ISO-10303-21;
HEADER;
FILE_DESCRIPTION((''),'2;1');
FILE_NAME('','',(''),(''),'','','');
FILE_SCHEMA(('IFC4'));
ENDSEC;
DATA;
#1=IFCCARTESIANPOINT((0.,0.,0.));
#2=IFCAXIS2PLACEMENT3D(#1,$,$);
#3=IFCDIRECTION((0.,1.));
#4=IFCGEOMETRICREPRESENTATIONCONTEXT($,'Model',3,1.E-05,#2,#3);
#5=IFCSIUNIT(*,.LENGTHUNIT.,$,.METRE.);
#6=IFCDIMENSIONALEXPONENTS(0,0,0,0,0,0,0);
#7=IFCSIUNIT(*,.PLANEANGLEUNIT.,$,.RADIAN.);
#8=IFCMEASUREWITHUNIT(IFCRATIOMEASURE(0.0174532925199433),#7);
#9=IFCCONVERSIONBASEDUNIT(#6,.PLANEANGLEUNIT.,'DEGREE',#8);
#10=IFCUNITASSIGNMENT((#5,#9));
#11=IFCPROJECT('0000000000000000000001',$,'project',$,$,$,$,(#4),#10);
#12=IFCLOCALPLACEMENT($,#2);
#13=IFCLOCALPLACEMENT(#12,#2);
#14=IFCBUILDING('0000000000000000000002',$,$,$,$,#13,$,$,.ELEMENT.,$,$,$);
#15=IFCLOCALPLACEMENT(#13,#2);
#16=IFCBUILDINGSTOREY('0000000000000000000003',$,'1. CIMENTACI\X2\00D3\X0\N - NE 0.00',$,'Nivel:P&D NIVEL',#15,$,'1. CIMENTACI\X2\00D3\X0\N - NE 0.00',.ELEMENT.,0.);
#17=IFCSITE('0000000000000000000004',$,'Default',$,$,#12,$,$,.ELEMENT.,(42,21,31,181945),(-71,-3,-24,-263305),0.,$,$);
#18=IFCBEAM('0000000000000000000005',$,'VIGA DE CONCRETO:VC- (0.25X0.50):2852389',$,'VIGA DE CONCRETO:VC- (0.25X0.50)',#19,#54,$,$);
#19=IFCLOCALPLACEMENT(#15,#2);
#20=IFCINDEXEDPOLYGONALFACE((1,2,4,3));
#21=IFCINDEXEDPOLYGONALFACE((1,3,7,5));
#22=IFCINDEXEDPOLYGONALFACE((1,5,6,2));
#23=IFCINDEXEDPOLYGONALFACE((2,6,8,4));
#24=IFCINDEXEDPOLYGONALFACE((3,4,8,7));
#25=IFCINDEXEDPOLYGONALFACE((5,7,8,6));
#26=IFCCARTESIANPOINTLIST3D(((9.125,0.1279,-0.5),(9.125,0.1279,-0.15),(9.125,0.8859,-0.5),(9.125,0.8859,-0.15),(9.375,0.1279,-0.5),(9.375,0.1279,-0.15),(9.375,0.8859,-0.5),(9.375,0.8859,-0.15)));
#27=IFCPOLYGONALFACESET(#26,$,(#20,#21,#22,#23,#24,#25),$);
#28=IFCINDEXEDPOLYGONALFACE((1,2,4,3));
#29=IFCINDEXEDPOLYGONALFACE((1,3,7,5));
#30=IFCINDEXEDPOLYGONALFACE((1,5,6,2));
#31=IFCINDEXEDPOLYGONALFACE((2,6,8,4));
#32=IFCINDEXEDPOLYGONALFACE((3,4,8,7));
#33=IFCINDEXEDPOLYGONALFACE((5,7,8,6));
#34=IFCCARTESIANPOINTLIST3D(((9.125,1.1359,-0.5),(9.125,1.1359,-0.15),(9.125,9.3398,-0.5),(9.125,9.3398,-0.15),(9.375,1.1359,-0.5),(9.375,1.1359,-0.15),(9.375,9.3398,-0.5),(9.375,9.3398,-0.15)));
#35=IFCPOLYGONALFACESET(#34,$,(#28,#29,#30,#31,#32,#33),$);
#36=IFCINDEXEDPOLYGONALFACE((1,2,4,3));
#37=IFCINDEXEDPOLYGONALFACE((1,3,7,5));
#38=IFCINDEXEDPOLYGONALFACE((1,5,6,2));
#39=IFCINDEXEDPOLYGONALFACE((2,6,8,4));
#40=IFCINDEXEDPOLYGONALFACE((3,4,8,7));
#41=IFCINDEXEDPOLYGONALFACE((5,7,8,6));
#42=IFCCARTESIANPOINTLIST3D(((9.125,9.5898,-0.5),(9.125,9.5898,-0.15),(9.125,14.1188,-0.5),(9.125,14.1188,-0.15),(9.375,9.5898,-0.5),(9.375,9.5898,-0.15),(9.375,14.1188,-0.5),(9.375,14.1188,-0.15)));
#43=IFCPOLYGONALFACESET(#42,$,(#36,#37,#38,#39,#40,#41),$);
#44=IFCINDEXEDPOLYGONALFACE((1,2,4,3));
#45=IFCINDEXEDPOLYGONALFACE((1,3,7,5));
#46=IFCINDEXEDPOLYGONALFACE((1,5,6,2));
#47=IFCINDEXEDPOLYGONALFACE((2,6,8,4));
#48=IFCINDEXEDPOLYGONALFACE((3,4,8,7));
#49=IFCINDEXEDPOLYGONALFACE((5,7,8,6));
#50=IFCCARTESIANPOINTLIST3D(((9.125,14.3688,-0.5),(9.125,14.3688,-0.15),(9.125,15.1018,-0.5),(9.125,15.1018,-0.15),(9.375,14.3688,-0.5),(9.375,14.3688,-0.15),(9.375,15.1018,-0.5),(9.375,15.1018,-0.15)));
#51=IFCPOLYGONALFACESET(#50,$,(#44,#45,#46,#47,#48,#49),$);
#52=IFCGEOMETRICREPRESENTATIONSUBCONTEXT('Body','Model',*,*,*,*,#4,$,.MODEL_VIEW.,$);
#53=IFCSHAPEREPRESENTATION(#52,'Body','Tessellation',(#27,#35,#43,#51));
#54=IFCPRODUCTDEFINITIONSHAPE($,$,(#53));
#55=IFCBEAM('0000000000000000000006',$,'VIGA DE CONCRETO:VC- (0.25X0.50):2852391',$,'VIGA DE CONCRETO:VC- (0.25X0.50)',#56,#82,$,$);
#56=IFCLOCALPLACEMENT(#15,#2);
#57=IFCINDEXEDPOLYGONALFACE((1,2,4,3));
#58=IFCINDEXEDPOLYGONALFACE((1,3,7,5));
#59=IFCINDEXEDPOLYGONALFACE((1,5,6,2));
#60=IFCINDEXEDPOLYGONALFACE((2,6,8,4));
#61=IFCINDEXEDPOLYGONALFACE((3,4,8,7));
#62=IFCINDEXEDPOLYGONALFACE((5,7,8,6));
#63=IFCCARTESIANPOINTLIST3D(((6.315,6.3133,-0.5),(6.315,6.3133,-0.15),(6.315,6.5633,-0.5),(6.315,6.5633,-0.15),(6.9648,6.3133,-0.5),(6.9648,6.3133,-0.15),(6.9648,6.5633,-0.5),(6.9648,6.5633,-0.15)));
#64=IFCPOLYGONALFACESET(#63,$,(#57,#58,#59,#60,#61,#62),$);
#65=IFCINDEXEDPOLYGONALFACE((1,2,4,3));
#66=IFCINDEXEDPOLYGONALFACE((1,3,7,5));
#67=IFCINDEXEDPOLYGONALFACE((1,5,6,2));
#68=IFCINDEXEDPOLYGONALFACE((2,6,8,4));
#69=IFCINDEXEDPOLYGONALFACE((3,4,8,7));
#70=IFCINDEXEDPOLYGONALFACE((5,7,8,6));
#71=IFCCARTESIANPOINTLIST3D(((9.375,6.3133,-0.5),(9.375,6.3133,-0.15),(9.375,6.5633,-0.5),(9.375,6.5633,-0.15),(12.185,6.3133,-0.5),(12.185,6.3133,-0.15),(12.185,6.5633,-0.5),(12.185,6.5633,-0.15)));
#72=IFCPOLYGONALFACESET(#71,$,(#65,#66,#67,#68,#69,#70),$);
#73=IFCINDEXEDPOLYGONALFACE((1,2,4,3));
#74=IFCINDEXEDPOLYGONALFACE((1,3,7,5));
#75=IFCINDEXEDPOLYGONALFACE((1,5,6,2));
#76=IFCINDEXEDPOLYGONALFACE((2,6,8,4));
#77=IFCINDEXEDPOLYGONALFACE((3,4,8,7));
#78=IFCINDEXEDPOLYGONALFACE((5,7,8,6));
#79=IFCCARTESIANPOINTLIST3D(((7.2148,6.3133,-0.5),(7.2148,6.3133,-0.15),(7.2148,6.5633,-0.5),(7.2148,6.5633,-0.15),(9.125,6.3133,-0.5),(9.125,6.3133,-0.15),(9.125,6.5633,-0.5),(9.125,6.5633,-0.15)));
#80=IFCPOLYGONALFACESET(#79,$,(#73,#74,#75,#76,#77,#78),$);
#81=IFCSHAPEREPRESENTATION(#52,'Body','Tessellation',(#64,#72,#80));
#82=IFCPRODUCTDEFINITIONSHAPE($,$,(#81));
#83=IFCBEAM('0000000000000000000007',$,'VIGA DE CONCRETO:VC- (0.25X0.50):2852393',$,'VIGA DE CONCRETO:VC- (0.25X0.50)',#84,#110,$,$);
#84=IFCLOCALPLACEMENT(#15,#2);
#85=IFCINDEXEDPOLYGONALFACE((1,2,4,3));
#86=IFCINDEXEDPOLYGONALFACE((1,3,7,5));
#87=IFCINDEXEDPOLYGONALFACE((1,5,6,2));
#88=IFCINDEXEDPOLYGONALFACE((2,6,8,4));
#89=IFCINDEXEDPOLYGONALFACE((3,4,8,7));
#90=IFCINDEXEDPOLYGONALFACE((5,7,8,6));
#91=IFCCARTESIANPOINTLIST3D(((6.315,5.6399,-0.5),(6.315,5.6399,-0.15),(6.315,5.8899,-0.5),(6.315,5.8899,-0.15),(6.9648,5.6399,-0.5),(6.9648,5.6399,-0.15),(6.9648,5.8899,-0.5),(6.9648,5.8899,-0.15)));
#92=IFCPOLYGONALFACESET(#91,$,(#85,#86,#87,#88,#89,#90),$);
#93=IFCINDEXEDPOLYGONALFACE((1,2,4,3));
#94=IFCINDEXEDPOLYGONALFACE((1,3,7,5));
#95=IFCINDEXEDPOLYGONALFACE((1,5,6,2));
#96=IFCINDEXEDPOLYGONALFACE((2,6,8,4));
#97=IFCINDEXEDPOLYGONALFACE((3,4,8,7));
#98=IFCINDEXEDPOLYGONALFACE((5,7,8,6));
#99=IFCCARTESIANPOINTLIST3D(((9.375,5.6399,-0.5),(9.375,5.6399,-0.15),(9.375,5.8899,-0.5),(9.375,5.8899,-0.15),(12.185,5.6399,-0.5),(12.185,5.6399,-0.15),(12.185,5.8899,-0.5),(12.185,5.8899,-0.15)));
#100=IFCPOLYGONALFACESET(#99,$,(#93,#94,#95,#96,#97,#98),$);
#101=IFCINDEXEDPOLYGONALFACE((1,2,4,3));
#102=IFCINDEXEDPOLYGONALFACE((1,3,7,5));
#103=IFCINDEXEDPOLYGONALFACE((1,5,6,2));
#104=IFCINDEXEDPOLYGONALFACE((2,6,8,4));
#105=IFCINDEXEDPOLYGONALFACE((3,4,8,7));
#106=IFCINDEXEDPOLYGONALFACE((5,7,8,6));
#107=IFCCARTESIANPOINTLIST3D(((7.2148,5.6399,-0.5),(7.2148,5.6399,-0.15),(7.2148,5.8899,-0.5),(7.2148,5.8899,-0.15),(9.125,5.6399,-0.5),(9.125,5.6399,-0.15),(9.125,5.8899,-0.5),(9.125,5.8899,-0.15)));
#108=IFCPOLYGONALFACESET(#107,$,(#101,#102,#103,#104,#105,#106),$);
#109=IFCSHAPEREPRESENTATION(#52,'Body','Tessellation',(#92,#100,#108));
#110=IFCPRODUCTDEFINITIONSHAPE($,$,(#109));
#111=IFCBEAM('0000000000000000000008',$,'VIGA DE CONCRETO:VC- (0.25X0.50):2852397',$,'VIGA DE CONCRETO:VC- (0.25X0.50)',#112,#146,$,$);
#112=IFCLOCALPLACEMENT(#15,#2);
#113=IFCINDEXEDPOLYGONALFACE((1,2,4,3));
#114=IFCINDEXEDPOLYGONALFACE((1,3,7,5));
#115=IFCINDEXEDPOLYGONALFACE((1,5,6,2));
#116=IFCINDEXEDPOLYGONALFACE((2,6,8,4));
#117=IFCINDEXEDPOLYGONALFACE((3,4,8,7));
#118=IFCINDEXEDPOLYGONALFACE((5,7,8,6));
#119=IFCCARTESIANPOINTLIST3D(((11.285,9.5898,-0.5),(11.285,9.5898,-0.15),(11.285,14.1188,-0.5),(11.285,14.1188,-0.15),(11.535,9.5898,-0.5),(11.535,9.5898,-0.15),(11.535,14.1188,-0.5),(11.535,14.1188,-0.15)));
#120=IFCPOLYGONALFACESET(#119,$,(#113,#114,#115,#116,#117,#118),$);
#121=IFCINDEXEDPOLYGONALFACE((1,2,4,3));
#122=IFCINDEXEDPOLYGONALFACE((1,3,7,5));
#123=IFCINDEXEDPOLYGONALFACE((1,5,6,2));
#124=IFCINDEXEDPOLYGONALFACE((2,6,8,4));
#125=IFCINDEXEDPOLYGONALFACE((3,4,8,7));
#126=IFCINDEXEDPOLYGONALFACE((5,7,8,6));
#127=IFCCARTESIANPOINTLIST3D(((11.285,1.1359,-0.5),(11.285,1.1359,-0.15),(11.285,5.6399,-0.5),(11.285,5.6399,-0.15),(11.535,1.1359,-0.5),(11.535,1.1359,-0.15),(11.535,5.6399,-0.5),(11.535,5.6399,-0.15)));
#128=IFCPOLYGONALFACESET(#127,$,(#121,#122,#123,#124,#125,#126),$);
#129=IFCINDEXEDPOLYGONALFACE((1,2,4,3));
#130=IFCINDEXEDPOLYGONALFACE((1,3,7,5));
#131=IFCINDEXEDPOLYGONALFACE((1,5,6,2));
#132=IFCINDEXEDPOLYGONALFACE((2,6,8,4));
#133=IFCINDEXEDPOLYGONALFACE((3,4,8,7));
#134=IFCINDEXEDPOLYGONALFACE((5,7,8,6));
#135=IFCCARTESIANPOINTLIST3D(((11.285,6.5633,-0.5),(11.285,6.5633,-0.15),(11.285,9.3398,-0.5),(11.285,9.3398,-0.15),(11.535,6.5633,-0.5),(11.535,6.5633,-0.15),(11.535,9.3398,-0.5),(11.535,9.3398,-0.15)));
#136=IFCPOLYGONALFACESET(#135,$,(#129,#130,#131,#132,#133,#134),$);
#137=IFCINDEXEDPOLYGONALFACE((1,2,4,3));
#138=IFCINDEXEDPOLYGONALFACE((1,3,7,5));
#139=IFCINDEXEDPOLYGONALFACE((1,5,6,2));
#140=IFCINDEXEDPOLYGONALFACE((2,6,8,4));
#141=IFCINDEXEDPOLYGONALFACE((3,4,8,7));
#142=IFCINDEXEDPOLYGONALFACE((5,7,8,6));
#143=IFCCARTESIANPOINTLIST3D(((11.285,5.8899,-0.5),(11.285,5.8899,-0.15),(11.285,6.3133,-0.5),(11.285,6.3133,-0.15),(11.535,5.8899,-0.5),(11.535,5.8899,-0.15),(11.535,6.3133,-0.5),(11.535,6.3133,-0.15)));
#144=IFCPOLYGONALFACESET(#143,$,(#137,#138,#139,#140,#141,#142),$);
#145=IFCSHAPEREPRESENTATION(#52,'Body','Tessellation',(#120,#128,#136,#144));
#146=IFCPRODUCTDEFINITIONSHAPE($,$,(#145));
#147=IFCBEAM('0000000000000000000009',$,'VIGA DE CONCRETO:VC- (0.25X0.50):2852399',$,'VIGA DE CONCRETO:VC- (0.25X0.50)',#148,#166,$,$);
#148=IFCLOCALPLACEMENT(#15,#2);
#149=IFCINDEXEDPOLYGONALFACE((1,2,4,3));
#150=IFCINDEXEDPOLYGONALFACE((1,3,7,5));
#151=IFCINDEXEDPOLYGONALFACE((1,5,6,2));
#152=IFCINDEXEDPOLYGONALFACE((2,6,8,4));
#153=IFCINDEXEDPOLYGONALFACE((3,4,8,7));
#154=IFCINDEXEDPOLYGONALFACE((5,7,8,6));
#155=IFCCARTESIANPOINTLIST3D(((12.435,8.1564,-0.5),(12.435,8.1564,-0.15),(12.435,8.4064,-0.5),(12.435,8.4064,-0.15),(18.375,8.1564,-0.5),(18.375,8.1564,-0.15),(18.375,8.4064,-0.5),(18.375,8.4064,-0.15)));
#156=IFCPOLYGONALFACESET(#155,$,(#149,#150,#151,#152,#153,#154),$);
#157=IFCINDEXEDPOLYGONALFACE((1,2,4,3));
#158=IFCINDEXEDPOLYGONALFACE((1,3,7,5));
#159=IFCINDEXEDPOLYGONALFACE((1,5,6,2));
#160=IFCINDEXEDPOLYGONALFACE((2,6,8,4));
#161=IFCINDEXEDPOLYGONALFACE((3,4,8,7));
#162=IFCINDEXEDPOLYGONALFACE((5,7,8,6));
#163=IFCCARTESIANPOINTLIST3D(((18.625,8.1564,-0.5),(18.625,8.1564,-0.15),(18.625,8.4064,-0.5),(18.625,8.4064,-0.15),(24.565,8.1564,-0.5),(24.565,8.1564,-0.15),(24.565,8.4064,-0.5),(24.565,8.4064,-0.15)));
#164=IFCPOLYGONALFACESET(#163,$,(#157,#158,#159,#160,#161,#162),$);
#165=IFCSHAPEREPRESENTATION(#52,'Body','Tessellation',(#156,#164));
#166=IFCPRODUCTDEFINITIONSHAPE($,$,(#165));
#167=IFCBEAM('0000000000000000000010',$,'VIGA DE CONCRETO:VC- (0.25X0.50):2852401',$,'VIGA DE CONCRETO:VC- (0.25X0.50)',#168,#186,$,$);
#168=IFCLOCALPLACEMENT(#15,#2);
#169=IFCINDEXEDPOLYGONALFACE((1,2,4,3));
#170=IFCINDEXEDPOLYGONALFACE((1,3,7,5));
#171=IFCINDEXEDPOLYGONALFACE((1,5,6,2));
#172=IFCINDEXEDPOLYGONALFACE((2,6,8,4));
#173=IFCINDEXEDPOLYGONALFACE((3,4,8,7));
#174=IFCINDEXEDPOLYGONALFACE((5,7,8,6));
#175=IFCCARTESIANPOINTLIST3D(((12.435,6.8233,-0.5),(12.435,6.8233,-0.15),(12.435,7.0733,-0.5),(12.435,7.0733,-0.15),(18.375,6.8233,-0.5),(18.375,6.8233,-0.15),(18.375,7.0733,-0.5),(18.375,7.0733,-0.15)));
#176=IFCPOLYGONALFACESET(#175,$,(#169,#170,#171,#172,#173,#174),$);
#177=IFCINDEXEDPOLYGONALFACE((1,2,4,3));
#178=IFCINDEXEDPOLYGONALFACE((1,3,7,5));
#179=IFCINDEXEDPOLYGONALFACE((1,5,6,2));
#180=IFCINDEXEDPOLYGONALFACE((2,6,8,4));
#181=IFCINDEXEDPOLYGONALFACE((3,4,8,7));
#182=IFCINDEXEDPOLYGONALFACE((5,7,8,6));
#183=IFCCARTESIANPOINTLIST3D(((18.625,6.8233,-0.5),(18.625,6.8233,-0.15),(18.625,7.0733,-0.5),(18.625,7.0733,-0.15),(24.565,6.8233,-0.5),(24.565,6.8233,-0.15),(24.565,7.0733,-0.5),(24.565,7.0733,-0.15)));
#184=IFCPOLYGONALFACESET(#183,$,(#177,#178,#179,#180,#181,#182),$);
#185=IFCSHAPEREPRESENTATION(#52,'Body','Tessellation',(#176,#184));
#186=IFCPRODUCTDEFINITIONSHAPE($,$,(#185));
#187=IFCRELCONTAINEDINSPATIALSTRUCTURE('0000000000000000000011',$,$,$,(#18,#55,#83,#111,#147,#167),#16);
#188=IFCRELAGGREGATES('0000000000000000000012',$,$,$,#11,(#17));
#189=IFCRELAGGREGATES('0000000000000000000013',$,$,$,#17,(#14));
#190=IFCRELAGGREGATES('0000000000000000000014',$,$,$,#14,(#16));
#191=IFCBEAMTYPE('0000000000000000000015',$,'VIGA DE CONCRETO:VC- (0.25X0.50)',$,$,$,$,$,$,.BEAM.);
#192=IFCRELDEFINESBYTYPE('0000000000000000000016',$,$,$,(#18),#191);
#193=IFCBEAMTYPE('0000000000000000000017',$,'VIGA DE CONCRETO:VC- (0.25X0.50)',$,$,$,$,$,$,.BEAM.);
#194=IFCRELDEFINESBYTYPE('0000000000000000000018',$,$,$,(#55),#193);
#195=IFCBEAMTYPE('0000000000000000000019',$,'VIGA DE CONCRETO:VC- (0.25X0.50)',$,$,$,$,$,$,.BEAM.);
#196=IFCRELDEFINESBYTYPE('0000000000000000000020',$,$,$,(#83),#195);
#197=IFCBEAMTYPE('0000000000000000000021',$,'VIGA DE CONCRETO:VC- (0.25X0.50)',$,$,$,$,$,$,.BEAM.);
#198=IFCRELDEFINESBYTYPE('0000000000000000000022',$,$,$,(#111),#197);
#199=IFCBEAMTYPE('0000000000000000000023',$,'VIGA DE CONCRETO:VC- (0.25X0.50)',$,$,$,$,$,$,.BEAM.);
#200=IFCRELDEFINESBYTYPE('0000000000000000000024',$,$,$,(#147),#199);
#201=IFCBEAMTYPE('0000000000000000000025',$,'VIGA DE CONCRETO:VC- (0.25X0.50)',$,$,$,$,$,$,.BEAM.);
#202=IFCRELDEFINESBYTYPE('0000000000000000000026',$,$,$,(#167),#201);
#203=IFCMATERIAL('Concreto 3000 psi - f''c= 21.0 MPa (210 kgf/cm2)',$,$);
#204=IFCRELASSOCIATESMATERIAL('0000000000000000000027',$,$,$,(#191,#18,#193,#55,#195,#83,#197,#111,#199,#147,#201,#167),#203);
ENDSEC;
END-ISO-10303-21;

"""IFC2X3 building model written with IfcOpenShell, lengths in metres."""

from ifc_helpers import new_model, entity, si_unit, converted_unit, direction, frame, frame_2d, origin, place, context, subcontext, project, spatial, rectangle, extrude, source, transform, mapped, material, type_object, type_shapes, element, save


model = new_model("IFC2X3")

# Units and contexts
model_context = context("Model", 3, precision=1e-05, world=origin(), true_north=direction((0.0, 1.0)))
body_context = subcontext(model_context, "Body", "Model", "MODEL_VIEW")
ifc_project = project(units=[si_unit("LENGTHUNIT", "METRE"), converted_unit("PLANEANGLEUNIT", "DEGREE", entity("IfcRatioMeasure", 0.0174532925199433), si_unit("PLANEANGLEUNIT", "RADIAN"), dimensions=[0, 0, 0, 0, 0, 0, 0])], contexts=[model_context])

# Site, building, storey
site_placement = place(None, origin())
site = spatial("IfcSite", under=ifc_project, at=site_placement, Name="Default", CompositionType="ELEMENT", RefLatitude=(42, 21, 31, 181945), RefLongitude=(-71, -3, -24, -263305), RefElevation=0.0)
building_placement = place(site_placement, origin())
building = spatial("IfcBuilding", under=site, at=building_placement, CompositionType="ELEMENT")
storey_placement = place(building_placement, origin())
storey = spatial("IfcBuildingStorey", under=building, at=storey_placement, Name="1. CIMENTACIÓN - NE 0.00", ObjectType="Nivel:P&D NIVEL", LongName="1. CIMENTACIÓN - NE 0.00", CompositionType="ELEMENT", Elevation=0.0)

# Beams
ifc_material = material(Name="Concreto 3000 psi - f'c= 21.0 MPa (210 kgf/cm2)")
beam_type_1 = type_object("IfcBeamType", Name="VIGA DE CONCRETO:VC- (0.25X0.50)", PredefinedType="BEAM", material=ifc_material)
shared_shape_1 = source(origin(), body_context, "Body", "SweptSolid", [
    extrude(rectangle(XDim=0.35, YDim=0.25, at=frame_2d((0.0, 0.0), x_axis=(0.0, 1.0))), frame((9.25, 0.1279, -0.325), z_axis=(0.0, 1.0, 0.0), x_axis=(-1.0, 0.0, 0.0)), (0.0, 0.0, 1.0), 0.758),
    extrude(rectangle(XDim=0.35, YDim=0.25, at=frame_2d((0.0, 0.0), x_axis=(0.0, 1.0))), frame((9.25, 1.1359, -0.325), z_axis=(0.0, 1.0, 0.0), x_axis=(-1.0, 0.0, 0.0)), (0.0, 0.0, 1.0), 8.2039),
    extrude(rectangle(XDim=0.35, YDim=0.25, at=frame_2d((0.0, 0.0), x_axis=(0.0, 1.0))), frame((9.25, 9.5898, -0.325), z_axis=(0.0, 1.0, 0.0), x_axis=(-1.0, 0.0, 0.0)), (0.0, 0.0, 1.0), 4.529),
    extrude(rectangle(XDim=0.35, YDim=0.25, at=frame_2d((0.0, 0.0), x_axis=(0.0, 1.0))), frame((9.25, 14.3688, -0.325), z_axis=(0.0, 1.0, 0.0), x_axis=(-1.0, 0.0, 0.0)), (0.0, 0.0, 1.0), 0.733),
])
type_shapes(beam_type_1, [shared_shape_1])
beam_1_placement = place(storey_placement, origin())
element("IfcBeam", 1, at=beam_1_placement, inside=storey, type_object=beam_type_1, material=ifc_material, Name="VIGA DE CONCRETO:VC- (0.25X0.50):2852389", ObjectType="VIGA DE CONCRETO:VC- (0.25X0.50)", context=body_context, shape_type="MappedRepresentation", body=[
    mapped(shared_shape_1, transform((0.0, 0.0, 0.0), scale=1.0)),
])
beam_type_2 = type_object("IfcBeamType", Name="VIGA DE CONCRETO:VC- (0.25X0.50)", PredefinedType="BEAM", material=ifc_material)
shared_shape_2 = source(origin(), body_context, "Body", "SweptSolid", [
    extrude(rectangle(XDim=0.35, YDim=0.25, at=frame_2d((0.0, 0.0), x_axis=(1.0, 0.0))), frame((6.315, 6.4383, -0.325), z_axis=(1.0, 0.0, 0.0), x_axis=(0.0, 0.0, -1.0)), (0.0, 0.0, 1.0), 0.6498),
    extrude(rectangle(XDim=0.35, YDim=0.25, at=frame_2d((0.0, 0.0), x_axis=(1.0, 0.0))), frame((9.375, 6.4383, -0.325), z_axis=(1.0, 0.0, 0.0), x_axis=(0.0, 0.0, -1.0)), (0.0, 0.0, 1.0), 2.81),
    extrude(rectangle(XDim=0.35, YDim=0.25, at=frame_2d((0.0, 0.0), x_axis=(1.0, 0.0))), frame((7.2148, 6.4383, -0.325), z_axis=(1.0, 0.0, 0.0), x_axis=(0.0, 0.0, -1.0)), (0.0, 0.0, 1.0), 1.9102),
])
type_shapes(beam_type_2, [shared_shape_2])
beam_2_placement = place(storey_placement, origin())
element("IfcBeam", 2, at=beam_2_placement, inside=storey, type_object=beam_type_2, material=ifc_material, Name="VIGA DE CONCRETO:VC- (0.25X0.50):2852391", ObjectType="VIGA DE CONCRETO:VC- (0.25X0.50)", context=body_context, shape_type="MappedRepresentation", body=[
    mapped(shared_shape_2, transform((0.0, 0.0, 0.0), scale=1.0)),
])
beam_type_3 = type_object("IfcBeamType", Name="VIGA DE CONCRETO:VC- (0.25X0.50)", PredefinedType="BEAM", material=ifc_material)
shared_shape_3 = source(origin(), body_context, "Body", "SweptSolid", [
    extrude(rectangle(XDim=0.35, YDim=0.25, at=frame_2d((0.0, 0.0), x_axis=(1.0, 0.0))), frame((6.315, 5.7649, -0.325), z_axis=(1.0, 0.0, 0.0), x_axis=(0.0, 0.0, -1.0)), (0.0, 0.0, 1.0), 0.6498),
    extrude(rectangle(XDim=0.35, YDim=0.25, at=frame_2d((0.0, 0.0), x_axis=(1.0, 0.0))), frame((9.375, 5.7649, -0.325), z_axis=(1.0, 0.0, 0.0), x_axis=(0.0, 0.0, -1.0)), (0.0, 0.0, 1.0), 2.81),
    extrude(rectangle(XDim=0.35, YDim=0.25, at=frame_2d((0.0, 0.0), x_axis=(1.0, 0.0))), frame((7.2148, 5.7649, -0.325), z_axis=(1.0, 0.0, 0.0), x_axis=(0.0, 0.0, -1.0)), (0.0, 0.0, 1.0), 1.9102),
])
type_shapes(beam_type_3, [shared_shape_3])
beam_3_placement = place(storey_placement, origin())
element("IfcBeam", 3, at=beam_3_placement, inside=storey, type_object=beam_type_3, material=ifc_material, Name="VIGA DE CONCRETO:VC- (0.25X0.50):2852393", ObjectType="VIGA DE CONCRETO:VC- (0.25X0.50)", context=body_context, shape_type="MappedRepresentation", body=[
    mapped(shared_shape_3, transform((0.0, 0.0, 0.0), scale=1.0)),
])
beam_type_4 = type_object("IfcBeamType", Name="VIGA DE CONCRETO:VC- (0.25X0.50)", PredefinedType="BEAM", material=ifc_material)
shared_shape_4 = source(origin(), body_context, "Body", "SweptSolid", [
    extrude(rectangle(XDim=0.35, YDim=0.25, at=frame_2d((0.0, 0.0), x_axis=(0.0, 1.0))), frame((11.41, 14.1188, -0.325), z_axis=(0.0, -1.0, 0.0), x_axis=(-1.0, 0.0, 0.0)), (0.0, 0.0, 1.0), 4.529),
    extrude(rectangle(XDim=0.35, YDim=0.25, at=frame_2d((0.0, 0.0), x_axis=(0.0, 1.0))), frame((11.41, 5.6399, -0.325), z_axis=(0.0, -1.0, 0.0), x_axis=(-1.0, 0.0, 0.0)), (0.0, 0.0, 1.0), 4.504),
    extrude(rectangle(XDim=0.35, YDim=0.25, at=frame_2d((0.0, 0.0), x_axis=(0.0, 1.0))), frame((11.41, 9.3398, -0.325), z_axis=(0.0, -1.0, 0.0), x_axis=(-1.0, 0.0, 0.0)), (0.0, 0.0, 1.0), 2.7765),
    extrude(rectangle(XDim=0.35, YDim=0.25, at=frame_2d((0.0, 0.0), x_axis=(0.0, 1.0))), frame((11.41, 6.3133, -0.325), z_axis=(0.0, -1.0, 0.0), x_axis=(-1.0, 0.0, 0.0)), (0.0, 0.0, 1.0), 0.4234),
])
type_shapes(beam_type_4, [shared_shape_4])
beam_4_placement = place(storey_placement, origin())
element("IfcBeam", 4, at=beam_4_placement, inside=storey, type_object=beam_type_4, material=ifc_material, Name="VIGA DE CONCRETO:VC- (0.25X0.50):2852397", ObjectType="VIGA DE CONCRETO:VC- (0.25X0.50)", context=body_context, shape_type="MappedRepresentation", body=[
    mapped(shared_shape_4, transform((0.0, 0.0, 0.0), scale=1.0)),
])
beam_type_5 = type_object("IfcBeamType", Name="VIGA DE CONCRETO:VC- (0.25X0.50)", PredefinedType="BEAM", material=ifc_material)
shared_shape_5 = source(origin(), body_context, "Body", "SweptSolid", [
    extrude(rectangle(XDim=0.35, YDim=0.25, at=frame_2d((0.0, 0.0), x_axis=(1.0, 0.0))), frame((18.375, 8.2814, -0.325), z_axis=(-1.0, 0.0, 0.0), x_axis=(0.0, 0.0, -1.0)), (0.0, 0.0, 1.0), 5.94),
    extrude(rectangle(XDim=0.35, YDim=0.25, at=frame_2d((0.0, 0.0), x_axis=(1.0, 0.0))), frame((24.565, 8.2814, -0.325), z_axis=(-1.0, 0.0, 0.0), x_axis=(0.0, 0.0, -1.0)), (0.0, 0.0, 1.0), 5.94),
])
type_shapes(beam_type_5, [shared_shape_5])
beam_5_placement = place(storey_placement, origin())
element("IfcBeam", 5, at=beam_5_placement, inside=storey, type_object=beam_type_5, material=ifc_material, Name="VIGA DE CONCRETO:VC- (0.25X0.50):2852399", ObjectType="VIGA DE CONCRETO:VC- (0.25X0.50)", context=body_context, shape_type="MappedRepresentation", body=[
    mapped(shared_shape_5, transform((0.0, 0.0, 0.0), scale=1.0)),
])
beam_type_6 = type_object("IfcBeamType", Name="VIGA DE CONCRETO:VC- (0.25X0.50)", PredefinedType="BEAM", material=ifc_material)
shared_shape_6 = source(origin(), body_context, "Body", "SweptSolid", [
    extrude(rectangle(XDim=0.35, YDim=0.25, at=frame_2d((0.0, 0.0), x_axis=(1.0, 0.0))), frame((18.375, 6.9483, -0.325), z_axis=(-1.0, 0.0, 0.0), x_axis=(0.0, 0.0, -1.0)), (0.0, 0.0, 1.0), 5.94),
    extrude(rectangle(XDim=0.35, YDim=0.25, at=frame_2d((0.0, 0.0), x_axis=(1.0, 0.0))), frame((24.565, 6.9483, -0.325), z_axis=(-1.0, 0.0, 0.0), x_axis=(0.0, 0.0, -1.0)), (0.0, 0.0, 1.0), 5.94),
])
type_shapes(beam_type_6, [shared_shape_6])
beam_6_placement = place(storey_placement, origin())
element("IfcBeam", 6, at=beam_6_placement, inside=storey, type_object=beam_type_6, material=ifc_material, Name="VIGA DE CONCRETO:VC- (0.25X0.50):2852401", ObjectType="VIGA DE CONCRETO:VC- (0.25X0.50)", context=body_context, shape_type="MappedRepresentation", body=[
    mapped(shared_shape_6, transform((0.0, 0.0, 0.0), scale=1.0)),
])

save(model, "model.ifc")
